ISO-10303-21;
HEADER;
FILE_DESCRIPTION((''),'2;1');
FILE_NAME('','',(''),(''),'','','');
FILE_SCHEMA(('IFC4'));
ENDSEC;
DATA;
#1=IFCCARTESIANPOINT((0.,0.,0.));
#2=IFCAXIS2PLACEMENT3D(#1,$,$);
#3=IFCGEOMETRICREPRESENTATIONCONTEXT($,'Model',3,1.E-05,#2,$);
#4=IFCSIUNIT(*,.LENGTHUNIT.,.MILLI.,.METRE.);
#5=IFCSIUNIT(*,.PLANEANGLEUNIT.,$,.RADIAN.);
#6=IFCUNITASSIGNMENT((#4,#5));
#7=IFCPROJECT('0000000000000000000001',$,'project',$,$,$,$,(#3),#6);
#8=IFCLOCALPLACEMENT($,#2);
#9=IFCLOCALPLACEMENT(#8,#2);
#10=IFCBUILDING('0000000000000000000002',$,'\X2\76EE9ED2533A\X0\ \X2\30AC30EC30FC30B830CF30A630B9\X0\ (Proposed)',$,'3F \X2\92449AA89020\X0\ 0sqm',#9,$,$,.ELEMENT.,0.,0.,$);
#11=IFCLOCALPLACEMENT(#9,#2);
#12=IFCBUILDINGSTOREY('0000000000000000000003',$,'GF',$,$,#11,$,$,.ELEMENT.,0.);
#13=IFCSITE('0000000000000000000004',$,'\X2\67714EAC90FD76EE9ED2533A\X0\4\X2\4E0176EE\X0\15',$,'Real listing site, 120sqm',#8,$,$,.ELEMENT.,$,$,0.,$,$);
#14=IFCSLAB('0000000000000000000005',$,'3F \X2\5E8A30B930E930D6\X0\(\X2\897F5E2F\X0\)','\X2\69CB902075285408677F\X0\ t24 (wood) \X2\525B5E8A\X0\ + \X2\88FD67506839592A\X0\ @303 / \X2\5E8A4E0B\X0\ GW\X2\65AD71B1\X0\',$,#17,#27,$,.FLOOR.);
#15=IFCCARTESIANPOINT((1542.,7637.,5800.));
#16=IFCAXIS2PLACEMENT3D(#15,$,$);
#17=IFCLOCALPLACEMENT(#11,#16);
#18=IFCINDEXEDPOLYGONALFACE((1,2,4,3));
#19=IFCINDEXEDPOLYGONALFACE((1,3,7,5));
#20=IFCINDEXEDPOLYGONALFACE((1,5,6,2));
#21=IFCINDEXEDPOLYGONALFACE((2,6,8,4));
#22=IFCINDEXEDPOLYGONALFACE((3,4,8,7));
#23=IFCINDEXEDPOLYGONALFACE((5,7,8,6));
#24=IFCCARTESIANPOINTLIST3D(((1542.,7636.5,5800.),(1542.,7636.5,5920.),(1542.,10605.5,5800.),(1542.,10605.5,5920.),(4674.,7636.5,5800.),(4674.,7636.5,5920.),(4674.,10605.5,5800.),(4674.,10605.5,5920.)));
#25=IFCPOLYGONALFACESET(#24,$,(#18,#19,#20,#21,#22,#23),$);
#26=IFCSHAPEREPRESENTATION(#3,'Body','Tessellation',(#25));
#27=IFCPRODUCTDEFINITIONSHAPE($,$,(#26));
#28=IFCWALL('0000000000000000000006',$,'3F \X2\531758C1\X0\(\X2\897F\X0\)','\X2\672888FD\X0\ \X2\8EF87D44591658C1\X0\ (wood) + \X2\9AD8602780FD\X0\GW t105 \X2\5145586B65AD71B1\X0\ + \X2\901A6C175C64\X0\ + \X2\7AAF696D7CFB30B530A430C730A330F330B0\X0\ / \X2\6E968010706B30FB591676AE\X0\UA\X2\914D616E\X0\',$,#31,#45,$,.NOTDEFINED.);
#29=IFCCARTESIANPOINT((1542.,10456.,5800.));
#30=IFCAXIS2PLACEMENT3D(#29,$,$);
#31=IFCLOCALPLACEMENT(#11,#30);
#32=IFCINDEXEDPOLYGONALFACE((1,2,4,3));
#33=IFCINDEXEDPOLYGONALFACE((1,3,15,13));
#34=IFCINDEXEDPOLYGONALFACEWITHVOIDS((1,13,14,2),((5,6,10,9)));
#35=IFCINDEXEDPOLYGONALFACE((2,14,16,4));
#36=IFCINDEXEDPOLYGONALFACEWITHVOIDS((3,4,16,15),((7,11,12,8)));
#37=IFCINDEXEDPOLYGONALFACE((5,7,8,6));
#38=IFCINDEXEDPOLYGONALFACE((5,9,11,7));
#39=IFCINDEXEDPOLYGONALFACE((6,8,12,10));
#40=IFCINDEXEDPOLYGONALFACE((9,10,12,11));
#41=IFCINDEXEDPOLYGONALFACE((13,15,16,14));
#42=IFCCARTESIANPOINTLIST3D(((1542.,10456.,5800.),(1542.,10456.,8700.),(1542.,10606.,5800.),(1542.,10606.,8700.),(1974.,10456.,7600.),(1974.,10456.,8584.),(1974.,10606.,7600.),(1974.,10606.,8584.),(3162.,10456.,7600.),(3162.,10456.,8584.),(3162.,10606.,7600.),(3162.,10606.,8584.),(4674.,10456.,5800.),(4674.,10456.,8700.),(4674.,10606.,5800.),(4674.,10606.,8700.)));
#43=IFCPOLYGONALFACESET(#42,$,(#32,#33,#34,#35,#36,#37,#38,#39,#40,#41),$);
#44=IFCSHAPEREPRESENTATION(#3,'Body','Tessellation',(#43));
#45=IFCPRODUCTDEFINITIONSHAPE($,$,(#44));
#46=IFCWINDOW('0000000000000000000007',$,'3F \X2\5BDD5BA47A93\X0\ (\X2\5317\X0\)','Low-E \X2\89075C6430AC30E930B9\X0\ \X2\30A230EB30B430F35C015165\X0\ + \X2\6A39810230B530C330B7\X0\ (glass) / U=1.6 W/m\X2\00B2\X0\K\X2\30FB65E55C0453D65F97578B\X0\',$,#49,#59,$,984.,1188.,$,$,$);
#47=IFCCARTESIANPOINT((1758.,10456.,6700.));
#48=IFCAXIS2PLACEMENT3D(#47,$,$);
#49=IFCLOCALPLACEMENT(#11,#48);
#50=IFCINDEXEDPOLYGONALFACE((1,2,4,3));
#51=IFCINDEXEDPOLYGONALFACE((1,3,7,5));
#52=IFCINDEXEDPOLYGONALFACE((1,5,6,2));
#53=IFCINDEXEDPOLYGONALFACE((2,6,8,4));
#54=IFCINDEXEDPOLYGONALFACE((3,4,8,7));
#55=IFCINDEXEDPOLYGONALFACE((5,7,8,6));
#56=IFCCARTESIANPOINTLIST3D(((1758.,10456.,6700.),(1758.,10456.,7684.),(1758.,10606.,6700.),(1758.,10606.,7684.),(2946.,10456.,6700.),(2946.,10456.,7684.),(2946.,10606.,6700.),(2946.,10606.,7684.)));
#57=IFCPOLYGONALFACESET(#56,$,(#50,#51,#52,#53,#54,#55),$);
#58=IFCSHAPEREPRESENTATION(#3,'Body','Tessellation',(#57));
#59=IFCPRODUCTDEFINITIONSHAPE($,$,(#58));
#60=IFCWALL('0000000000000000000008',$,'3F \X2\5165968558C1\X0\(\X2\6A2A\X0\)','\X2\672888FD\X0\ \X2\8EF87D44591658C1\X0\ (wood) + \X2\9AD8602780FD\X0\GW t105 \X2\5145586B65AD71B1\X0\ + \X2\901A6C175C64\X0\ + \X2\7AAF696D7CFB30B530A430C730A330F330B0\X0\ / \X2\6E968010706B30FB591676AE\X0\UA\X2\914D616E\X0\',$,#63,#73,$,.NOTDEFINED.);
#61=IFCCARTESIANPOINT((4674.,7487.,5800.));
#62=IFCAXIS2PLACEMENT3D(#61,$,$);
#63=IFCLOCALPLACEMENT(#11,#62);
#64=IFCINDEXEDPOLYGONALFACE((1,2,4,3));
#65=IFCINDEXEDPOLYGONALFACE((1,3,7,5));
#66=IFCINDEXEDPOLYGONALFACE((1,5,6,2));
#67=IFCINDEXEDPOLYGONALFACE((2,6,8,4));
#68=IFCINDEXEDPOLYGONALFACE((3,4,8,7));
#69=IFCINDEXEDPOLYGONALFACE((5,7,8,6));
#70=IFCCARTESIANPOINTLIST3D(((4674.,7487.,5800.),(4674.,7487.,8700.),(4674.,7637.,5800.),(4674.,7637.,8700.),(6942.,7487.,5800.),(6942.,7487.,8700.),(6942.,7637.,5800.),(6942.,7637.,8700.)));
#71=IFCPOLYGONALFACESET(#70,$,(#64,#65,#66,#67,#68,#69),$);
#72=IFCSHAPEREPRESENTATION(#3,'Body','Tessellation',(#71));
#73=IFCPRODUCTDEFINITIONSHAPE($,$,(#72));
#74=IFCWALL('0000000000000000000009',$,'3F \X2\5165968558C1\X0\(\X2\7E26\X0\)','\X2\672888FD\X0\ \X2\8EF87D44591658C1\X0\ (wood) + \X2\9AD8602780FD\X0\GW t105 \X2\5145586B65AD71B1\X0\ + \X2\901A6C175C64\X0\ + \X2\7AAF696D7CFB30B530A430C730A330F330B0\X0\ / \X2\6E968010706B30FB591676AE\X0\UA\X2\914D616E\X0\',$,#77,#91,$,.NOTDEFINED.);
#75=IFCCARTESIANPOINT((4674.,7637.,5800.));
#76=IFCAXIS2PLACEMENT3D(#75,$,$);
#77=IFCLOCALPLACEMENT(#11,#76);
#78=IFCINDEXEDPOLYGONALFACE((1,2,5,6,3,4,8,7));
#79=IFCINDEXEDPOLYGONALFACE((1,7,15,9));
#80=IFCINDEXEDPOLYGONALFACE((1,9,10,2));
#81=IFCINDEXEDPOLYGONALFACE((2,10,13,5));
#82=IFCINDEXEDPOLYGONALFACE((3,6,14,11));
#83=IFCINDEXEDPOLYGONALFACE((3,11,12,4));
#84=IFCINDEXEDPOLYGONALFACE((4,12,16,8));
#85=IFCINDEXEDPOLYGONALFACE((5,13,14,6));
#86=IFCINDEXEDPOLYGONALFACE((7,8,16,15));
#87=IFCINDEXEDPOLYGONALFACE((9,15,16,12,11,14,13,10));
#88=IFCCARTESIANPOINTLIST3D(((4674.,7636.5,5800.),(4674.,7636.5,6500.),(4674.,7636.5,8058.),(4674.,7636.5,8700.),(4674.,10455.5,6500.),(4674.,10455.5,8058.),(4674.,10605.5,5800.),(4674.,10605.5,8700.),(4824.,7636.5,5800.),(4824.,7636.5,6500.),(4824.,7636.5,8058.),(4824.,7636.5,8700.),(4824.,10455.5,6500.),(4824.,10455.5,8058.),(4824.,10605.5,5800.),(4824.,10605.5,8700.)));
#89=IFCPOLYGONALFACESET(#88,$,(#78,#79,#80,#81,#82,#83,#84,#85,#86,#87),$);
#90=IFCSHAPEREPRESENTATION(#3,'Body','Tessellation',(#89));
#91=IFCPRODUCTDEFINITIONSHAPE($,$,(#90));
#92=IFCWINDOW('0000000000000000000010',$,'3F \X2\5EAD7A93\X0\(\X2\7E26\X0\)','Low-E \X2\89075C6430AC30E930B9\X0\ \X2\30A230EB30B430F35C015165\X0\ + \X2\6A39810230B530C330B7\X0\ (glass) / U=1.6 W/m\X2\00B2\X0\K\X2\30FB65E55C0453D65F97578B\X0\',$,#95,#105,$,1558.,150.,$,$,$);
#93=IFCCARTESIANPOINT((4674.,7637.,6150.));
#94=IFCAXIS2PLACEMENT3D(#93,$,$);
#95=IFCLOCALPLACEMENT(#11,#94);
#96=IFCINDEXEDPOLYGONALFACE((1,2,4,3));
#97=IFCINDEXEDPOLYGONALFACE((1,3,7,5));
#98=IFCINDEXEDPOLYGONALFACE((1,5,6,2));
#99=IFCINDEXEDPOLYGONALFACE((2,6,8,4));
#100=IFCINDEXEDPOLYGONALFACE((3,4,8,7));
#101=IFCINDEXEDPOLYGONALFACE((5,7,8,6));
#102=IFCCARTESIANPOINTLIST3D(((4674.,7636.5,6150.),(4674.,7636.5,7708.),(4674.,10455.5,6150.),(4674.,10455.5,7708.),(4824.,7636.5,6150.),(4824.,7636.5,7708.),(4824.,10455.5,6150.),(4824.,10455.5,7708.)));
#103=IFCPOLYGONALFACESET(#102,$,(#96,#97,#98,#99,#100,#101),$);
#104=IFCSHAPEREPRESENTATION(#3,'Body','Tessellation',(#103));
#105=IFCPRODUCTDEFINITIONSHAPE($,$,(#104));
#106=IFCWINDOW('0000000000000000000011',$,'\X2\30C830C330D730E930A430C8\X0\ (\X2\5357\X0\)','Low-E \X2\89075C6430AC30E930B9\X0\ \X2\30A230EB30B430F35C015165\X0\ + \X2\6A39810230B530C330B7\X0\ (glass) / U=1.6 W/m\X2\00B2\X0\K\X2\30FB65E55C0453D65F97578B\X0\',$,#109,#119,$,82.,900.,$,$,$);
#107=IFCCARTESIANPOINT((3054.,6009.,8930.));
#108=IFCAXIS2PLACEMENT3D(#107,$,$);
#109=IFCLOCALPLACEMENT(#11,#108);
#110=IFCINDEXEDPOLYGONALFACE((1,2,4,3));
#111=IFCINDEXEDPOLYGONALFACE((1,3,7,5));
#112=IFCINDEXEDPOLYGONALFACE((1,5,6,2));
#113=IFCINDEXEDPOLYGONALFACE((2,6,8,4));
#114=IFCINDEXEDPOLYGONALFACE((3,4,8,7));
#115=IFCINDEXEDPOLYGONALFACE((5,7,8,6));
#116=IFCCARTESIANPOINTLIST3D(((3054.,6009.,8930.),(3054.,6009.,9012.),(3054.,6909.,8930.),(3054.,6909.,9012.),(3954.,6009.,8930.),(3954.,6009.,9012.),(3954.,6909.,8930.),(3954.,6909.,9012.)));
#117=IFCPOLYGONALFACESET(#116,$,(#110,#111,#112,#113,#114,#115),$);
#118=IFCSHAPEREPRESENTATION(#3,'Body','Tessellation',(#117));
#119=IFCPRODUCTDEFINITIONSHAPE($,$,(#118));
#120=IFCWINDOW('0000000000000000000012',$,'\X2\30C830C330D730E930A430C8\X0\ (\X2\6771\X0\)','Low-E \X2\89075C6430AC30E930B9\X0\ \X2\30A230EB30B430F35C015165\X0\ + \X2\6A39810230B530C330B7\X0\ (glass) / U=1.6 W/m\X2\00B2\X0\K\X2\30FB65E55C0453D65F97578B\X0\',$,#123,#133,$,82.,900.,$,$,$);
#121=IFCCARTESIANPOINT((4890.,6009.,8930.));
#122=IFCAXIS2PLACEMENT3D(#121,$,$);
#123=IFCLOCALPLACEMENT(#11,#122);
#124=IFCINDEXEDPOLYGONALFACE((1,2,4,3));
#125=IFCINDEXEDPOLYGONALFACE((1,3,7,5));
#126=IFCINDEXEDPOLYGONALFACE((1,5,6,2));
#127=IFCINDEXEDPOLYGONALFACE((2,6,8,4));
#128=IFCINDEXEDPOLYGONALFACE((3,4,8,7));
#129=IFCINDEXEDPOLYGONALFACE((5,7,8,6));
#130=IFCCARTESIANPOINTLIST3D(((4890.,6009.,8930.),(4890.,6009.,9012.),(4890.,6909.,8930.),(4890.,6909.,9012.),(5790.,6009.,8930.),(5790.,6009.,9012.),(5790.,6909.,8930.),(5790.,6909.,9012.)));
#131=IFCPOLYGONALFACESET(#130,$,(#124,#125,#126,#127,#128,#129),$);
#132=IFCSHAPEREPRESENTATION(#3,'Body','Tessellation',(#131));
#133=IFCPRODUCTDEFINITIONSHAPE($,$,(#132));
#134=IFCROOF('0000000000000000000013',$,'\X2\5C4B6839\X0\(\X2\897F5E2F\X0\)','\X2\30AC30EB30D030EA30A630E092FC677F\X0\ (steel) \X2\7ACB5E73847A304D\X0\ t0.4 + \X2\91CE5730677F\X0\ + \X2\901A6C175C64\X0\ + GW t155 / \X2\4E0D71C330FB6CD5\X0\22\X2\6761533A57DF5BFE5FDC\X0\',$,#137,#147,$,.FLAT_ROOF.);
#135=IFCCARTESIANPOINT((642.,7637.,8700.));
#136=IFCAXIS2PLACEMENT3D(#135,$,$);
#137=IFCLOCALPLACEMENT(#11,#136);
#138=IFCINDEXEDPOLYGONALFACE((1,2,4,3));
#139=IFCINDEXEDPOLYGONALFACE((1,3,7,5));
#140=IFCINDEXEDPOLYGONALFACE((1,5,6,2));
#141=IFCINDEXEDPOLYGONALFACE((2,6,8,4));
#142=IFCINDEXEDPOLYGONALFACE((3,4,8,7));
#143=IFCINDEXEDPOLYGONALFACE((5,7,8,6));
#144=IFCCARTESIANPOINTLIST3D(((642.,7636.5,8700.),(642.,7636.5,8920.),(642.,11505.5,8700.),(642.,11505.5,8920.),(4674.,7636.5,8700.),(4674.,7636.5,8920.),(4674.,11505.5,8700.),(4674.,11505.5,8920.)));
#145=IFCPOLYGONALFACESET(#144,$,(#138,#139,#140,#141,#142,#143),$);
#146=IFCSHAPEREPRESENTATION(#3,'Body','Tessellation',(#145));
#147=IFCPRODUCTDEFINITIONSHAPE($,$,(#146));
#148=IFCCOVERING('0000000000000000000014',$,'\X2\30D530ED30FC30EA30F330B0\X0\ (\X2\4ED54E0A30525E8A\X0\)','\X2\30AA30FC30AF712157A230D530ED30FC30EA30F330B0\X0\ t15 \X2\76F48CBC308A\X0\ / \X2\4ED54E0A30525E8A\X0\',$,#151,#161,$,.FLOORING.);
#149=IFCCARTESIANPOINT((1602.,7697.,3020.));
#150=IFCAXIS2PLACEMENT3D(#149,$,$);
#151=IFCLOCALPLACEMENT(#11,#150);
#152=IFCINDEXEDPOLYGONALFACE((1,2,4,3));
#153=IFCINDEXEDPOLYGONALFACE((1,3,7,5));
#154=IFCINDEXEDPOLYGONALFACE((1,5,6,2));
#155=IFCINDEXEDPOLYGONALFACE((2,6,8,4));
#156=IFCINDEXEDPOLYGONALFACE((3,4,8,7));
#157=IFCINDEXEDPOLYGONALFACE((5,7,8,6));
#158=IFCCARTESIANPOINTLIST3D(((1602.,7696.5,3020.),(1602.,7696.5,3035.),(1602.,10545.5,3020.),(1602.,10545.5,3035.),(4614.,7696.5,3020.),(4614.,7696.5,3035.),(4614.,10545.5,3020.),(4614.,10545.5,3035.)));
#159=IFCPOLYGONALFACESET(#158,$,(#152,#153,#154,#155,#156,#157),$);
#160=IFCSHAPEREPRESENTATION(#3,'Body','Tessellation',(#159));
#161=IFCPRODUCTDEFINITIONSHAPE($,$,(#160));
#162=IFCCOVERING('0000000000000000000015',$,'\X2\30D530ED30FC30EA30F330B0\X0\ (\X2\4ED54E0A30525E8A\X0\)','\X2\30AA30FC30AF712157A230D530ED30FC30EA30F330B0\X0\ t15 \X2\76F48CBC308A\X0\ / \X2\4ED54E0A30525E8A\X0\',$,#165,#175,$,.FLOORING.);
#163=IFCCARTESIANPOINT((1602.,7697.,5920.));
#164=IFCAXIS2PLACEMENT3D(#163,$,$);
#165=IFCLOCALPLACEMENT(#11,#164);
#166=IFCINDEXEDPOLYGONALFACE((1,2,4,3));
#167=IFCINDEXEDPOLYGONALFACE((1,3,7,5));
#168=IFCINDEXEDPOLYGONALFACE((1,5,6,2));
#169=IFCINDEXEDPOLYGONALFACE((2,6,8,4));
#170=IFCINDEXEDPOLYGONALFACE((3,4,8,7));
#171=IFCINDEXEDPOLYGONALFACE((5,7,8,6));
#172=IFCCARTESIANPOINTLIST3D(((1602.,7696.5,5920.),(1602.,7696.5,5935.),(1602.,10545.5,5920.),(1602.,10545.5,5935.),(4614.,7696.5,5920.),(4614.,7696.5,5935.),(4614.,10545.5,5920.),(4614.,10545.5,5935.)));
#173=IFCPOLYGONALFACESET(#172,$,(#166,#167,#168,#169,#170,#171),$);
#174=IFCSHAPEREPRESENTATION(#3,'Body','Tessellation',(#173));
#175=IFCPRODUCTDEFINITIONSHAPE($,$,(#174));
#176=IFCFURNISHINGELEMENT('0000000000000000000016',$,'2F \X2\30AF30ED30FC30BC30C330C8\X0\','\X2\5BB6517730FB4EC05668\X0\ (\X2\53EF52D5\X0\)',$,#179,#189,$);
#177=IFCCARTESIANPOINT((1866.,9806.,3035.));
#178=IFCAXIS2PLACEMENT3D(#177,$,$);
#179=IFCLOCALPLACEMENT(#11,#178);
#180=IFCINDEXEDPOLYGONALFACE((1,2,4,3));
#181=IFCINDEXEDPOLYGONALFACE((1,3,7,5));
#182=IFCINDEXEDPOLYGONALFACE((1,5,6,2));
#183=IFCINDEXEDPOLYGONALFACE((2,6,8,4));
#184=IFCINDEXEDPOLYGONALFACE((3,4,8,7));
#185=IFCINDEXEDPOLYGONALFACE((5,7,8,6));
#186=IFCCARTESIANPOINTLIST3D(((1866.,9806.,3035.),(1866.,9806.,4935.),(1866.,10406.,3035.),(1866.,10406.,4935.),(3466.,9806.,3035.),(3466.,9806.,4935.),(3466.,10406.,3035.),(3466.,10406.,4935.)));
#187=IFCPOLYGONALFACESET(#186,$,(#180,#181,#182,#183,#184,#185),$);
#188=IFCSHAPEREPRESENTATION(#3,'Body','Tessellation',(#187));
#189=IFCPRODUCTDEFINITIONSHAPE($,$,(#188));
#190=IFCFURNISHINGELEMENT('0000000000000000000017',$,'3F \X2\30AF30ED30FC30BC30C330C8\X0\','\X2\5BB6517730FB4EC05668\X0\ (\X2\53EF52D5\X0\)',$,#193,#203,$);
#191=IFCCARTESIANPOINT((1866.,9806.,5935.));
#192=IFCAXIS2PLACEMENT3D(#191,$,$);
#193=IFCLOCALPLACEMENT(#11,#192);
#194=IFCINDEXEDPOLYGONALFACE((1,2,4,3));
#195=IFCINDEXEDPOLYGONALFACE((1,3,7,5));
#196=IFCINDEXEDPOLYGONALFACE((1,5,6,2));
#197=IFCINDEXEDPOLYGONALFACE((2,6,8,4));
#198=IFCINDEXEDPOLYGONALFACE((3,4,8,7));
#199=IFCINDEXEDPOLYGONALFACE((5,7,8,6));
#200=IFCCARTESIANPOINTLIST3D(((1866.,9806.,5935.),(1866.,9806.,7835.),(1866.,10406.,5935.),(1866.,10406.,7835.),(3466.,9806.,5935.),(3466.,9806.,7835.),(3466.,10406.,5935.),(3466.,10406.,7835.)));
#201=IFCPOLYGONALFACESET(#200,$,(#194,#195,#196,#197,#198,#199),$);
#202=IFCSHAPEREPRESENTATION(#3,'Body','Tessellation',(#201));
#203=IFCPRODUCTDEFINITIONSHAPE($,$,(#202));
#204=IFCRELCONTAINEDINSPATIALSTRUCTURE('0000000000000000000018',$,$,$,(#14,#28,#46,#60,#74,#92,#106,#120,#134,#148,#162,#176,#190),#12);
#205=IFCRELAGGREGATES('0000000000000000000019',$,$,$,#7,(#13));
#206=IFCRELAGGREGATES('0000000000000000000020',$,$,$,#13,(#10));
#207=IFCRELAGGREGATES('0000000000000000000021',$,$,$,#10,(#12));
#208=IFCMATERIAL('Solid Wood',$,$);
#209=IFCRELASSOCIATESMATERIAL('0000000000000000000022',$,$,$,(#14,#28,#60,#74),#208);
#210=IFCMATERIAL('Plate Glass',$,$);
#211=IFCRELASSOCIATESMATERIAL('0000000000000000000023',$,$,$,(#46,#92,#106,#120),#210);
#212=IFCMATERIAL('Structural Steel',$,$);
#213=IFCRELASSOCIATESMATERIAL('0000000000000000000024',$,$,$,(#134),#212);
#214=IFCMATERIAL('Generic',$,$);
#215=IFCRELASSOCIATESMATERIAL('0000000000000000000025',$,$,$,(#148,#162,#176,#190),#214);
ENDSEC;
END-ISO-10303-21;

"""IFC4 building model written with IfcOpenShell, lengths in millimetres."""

from ifc_helpers import new_model, si_unit, frame, frame_2d, origin, place, context, project, spatial, rectangle, extrude, material, element, fill, save


model = new_model("IFC4")

# Units and contexts
model_context = context("Model", 3, precision=1e-05, world=origin())
ifc_project = project(units=[si_unit("LENGTHUNIT", "METRE", prefix="MILLI"), si_unit("PLANEANGLEUNIT", "RADIAN")], contexts=[model_context])

# Site, building, storey
site_placement = place(None, origin())
site = spatial("IfcSite", under=ifc_project, at=site_placement, Name="東京都目黒区4丁目15", ObjectType="Real listing site, 120sqm", CompositionType="ELEMENT", RefElevation=0.0)
building_placement = place(site_placement, origin())
building = spatial("IfcBuilding", under=site, at=building_placement, Name="目黒区 ガレージハウス (Proposed)", ObjectType="3F 鉄骨造 0sqm", CompositionType="ELEMENT", ElevationOfRefHeight=0.0, ElevationOfTerrain=0.0)
storey_placement = place(building_placement, origin())
storey = spatial("IfcBuildingStorey", under=building, at=storey_placement, Name="GF", CompositionType="ELEMENT", Elevation=0.0)

# Slab
ifc_material_1 = material(Name="Solid Wood")
slab_placement = place(storey_placement, frame((1542.0, 7637.0, 5800.0)))
element("IfcSlab", 1, at=slab_placement, inside=storey, material=ifc_material_1, Name="3F 床スラブ(西帯)", Description="構造用合板 t24 (wood) 剛床 + 製材根太 @303 / 床下 GW断熱", PredefinedType="FLOOR", context=model_context, shape_type="SweptSolid", body=[
    extrude(rectangle(XDim=3132.0, YDim=2969.0, at=frame_2d((1566.0, 1484.0))), frame((1542.0, 7637.0, 5800.0)), (0.0, 0.0, 1.0), 120.0),
])

# Wall, opening, window
wall_1_placement = place(storey_placement, frame((1542.0, 10456.0, 5800.0)))
wall_1 = element("IfcWall", 2, at=wall_1_placement, inside=storey, material=ifc_material_1, Name="3F 北壁(西)", Description="木製 軸組外壁 (wood) + 高性能GW t105 充填断熱 + 通気層 + 窯業系サイディング / 準耐火・外皮UA配慮", PredefinedType="NOTDEFINED", context=model_context, shape_type="SweptSolid", body=[
    extrude(rectangle(XDim=3132.0, YDim=150.0, at=frame_2d((1566.0, 75.0))), frame((1542.0, 10456.0, 5800.0)), (0.0, 0.0, 1.0), 2900.0),
])
opening_1_placement = place(storey_placement, frame((1758.0, 10456.0, 6700.0)))
opening_1 = element("IfcOpeningElement", 3, at=opening_1_placement, cuts=wall_1, PredefinedType="NOTDEFINED", context=model_context, shape_type="SweptSolid", body=[
    extrude(rectangle(XDim=1188.0, YDim=150.0, at=frame_2d((594.0, 75.0))), frame((1758.0, 10456.0, 6700.0)), (0.0, 0.0, 1.0), 984.0),
])
ifc_material_2 = material(Name="Plate Glass")
window_1_placement = place(storey_placement, frame((1758.0, 10456.0, 6700.0)))
window_1 = element("IfcWindow", 4, at=window_1_placement, inside=storey, material=ifc_material_2, Name="3F 寝室窓 (北)", Description="Low-E 複層ガラス アルゴン封入 + 樹脂サッシ (glass) / U=1.6 W/m²K・日射取得型", OverallHeight=984.0, OverallWidth=1188.0, context=model_context, shape_type="SweptSolid", body=[
    extrude(rectangle(XDim=1188.0, YDim=150.0, at=frame_2d((594.0, 75.0))), frame((1758.0, 10456.0, 6700.0)), (0.0, 0.0, 1.0), 984.0),
])
fill(opening_1, window_1)

# Wall
wall_2_placement = place(storey_placement, frame((4674.0, 7487.0, 5800.0)))
element("IfcWall", 5, at=wall_2_placement, inside=storey, material=ifc_material_1, Name="3F 入隅壁(横)", Description="木製 軸組外壁 (wood) + 高性能GW t105 充填断熱 + 通気層 + 窯業系サイディング / 準耐火・外皮UA配慮", PredefinedType="NOTDEFINED", context=model_context, shape_type="SweptSolid", body=[
    extrude(rectangle(XDim=2268.0, YDim=150.0, at=frame_2d((1134.0, 75.0))), frame((4674.0, 7487.0, 5800.0)), (0.0, 0.0, 1.0), 2900.0),
])

# Wall, opening, window
wall_3_placement = place(storey_placement, frame((4674.0, 7637.0, 5800.0)))
wall_3 = element("IfcWall", 6, at=wall_3_placement, inside=storey, material=ifc_material_1, Name="3F 入隅壁(縦)", Description="木製 軸組外壁 (wood) + 高性能GW t105 充填断熱 + 通気層 + 窯業系サイディング / 準耐火・外皮UA配慮", PredefinedType="NOTDEFINED", context=model_context, shape_type="SweptSolid", body=[
    extrude(rectangle(XDim=150.0, YDim=2969.0, at=frame_2d((75.0, 1484.0))), frame((4674.0, 7637.0, 5800.0)), (0.0, 0.0, 1.0), 2900.0),
])
opening_2_placement = place(storey_placement, frame((4674.0, 7637.0, 6150.0)))
opening_2 = element("IfcOpeningElement", 7, at=opening_2_placement, cuts=wall_3, PredefinedType="NOTDEFINED", context=model_context, shape_type="SweptSolid", body=[
    extrude(rectangle(XDim=150.0, YDim=2819.0, at=frame_2d((75.0, 1409.0))), frame((4674.0, 7637.0, 6150.0)), (0.0, 0.0, 1.0), 1558.0),
])
window_2_placement = place(storey_placement, frame((4674.0, 7637.0, 6150.0)))
window_2 = element("IfcWindow", 8, at=window_2_placement, inside=storey, material=ifc_material_2, Name="3F 庭窓(縦)", Description="Low-E 複層ガラス アルゴン封入 + 樹脂サッシ (glass) / U=1.6 W/m²K・日射取得型", OverallHeight=1558.0, OverallWidth=150.0, context=model_context, shape_type="SweptSolid", body=[
    extrude(rectangle(XDim=150.0, YDim=2819.0, at=frame_2d((75.0, 1409.0))), frame((4674.0, 7637.0, 6150.0)), (0.0, 0.0, 1.0), 1558.0),
])
fill(opening_2, window_2)

# Windows
window_3_placement = place(storey_placement, frame((3054.0, 6009.0, 8930.0)))
element("IfcWindow", 9, at=window_3_placement, inside=storey, material=ifc_material_2, Name="トップライト (南)", Description="Low-E 複層ガラス アルゴン封入 + 樹脂サッシ (glass) / U=1.6 W/m²K・日射取得型", OverallHeight=82.0, OverallWidth=900.0, context=model_context, shape_type="SweptSolid", body=[
    extrude(rectangle(XDim=900.0, YDim=900.0, at=frame_2d((450.0, 450.0))), frame((3054.0, 6009.0, 8930.0)), (0.0, 0.0, 1.0), 82.0),
])
window_4_placement = place(storey_placement, frame((4890.0, 6009.0, 8930.0)))
element("IfcWindow", 10, at=window_4_placement, inside=storey, material=ifc_material_2, Name="トップライト (東)", Description="Low-E 複層ガラス アルゴン封入 + 樹脂サッシ (glass) / U=1.6 W/m²K・日射取得型", OverallHeight=82.0, OverallWidth=900.0, context=model_context, shape_type="SweptSolid", body=[
    extrude(rectangle(XDim=900.0, YDim=900.0, at=frame_2d((450.0, 450.0))), frame((4890.0, 6009.0, 8930.0)), (0.0, 0.0, 1.0), 82.0),
])

# Roof
ifc_material_3 = material(Name="Structural Steel")
for number, where, name in (
    (11, (642.0, 7637.0, 8700.0), "屋根(西帯)"),
):
    element("IfcRoof", number, at=place(storey_placement, frame(where)), inside=storey, material=ifc_material_3, Name=name, Description="ガルバリウム鋼板 (steel) 立平葺き t0.4 + 野地板 + 通気層 + GW t155 / 不燃・法22条区域対応", PredefinedType="FLAT_ROOF", context=model_context, shape_type="SweptSolid", body=[
        extrude(rectangle(XDim=4032.0, YDim=3869.0, at=frame_2d((2016.0, 1934.0))), frame((642.0, 7637.0, 8700.0)), (0.0, 0.0, 1.0), 220.0),
    ])

# Coverings
ifc_material_4 = material(Name="Generic")
covering_1_placement = place(storey_placement, frame((1602.0, 7697.0, 3020.0)))
element("IfcCovering", 12, at=covering_1_placement, inside=storey, material=ifc_material_4, Name="フローリング (仕上げ床)", Description="オーク無垢フローリング t15 直貼り / 仕上げ床", PredefinedType="FLOORING", context=model_context, shape_type="SweptSolid", body=[
    extrude(rectangle(XDim=3012.0, YDim=2849.0, at=frame_2d((1506.0, 1424.0))), frame((1602.0, 7697.0, 3020.0)), (0.0, 0.0, 1.0), 15.0),
])
covering_2_placement = place(storey_placement, frame((1602.0, 7697.0, 5920.0)))
element("IfcCovering", 13, at=covering_2_placement, inside=storey, material=ifc_material_4, Name="フローリング (仕上げ床)", Description="オーク無垢フローリング t15 直貼り / 仕上げ床", PredefinedType="FLOORING", context=model_context, shape_type="SweptSolid", body=[
    extrude(rectangle(XDim=3012.0, YDim=2849.0, at=frame_2d((1506.0, 1424.0))), frame((1602.0, 7697.0, 5920.0)), (0.0, 0.0, 1.0), 15.0),
])

# Furnishing elements
furnishing_1_placement = place(storey_placement, frame((1866.0, 9806.0, 3035.0)))
element("IfcFurnishingElement", 14, at=furnishing_1_placement, inside=storey, material=ifc_material_4, Name="2F クローゼット", Description="家具・什器 (可動)", context=model_context, shape_type="SweptSolid", body=[
    extrude(rectangle(XDim=1600.0, YDim=600.0, at=frame_2d((800.0, 300.0))), frame((1866.0, 9806.0, 3035.0)), (0.0, 0.0, 1.0), 1900.0),
])
furnishing_2_placement = place(storey_placement, frame((1866.0, 9806.0, 5935.0)))
element("IfcFurnishingElement", 15, at=furnishing_2_placement, inside=storey, material=ifc_material_4, Name="3F クローゼット", Description="家具・什器 (可動)", context=model_context, shape_type="SweptSolid", body=[
    extrude(rectangle(XDim=1600.0, YDim=600.0, at=frame_2d((800.0, 300.0))), frame((1866.0, 9806.0, 5935.0)), (0.0, 0.0, 1.0), 1900.0),
])

save(model, "model.ifc")
